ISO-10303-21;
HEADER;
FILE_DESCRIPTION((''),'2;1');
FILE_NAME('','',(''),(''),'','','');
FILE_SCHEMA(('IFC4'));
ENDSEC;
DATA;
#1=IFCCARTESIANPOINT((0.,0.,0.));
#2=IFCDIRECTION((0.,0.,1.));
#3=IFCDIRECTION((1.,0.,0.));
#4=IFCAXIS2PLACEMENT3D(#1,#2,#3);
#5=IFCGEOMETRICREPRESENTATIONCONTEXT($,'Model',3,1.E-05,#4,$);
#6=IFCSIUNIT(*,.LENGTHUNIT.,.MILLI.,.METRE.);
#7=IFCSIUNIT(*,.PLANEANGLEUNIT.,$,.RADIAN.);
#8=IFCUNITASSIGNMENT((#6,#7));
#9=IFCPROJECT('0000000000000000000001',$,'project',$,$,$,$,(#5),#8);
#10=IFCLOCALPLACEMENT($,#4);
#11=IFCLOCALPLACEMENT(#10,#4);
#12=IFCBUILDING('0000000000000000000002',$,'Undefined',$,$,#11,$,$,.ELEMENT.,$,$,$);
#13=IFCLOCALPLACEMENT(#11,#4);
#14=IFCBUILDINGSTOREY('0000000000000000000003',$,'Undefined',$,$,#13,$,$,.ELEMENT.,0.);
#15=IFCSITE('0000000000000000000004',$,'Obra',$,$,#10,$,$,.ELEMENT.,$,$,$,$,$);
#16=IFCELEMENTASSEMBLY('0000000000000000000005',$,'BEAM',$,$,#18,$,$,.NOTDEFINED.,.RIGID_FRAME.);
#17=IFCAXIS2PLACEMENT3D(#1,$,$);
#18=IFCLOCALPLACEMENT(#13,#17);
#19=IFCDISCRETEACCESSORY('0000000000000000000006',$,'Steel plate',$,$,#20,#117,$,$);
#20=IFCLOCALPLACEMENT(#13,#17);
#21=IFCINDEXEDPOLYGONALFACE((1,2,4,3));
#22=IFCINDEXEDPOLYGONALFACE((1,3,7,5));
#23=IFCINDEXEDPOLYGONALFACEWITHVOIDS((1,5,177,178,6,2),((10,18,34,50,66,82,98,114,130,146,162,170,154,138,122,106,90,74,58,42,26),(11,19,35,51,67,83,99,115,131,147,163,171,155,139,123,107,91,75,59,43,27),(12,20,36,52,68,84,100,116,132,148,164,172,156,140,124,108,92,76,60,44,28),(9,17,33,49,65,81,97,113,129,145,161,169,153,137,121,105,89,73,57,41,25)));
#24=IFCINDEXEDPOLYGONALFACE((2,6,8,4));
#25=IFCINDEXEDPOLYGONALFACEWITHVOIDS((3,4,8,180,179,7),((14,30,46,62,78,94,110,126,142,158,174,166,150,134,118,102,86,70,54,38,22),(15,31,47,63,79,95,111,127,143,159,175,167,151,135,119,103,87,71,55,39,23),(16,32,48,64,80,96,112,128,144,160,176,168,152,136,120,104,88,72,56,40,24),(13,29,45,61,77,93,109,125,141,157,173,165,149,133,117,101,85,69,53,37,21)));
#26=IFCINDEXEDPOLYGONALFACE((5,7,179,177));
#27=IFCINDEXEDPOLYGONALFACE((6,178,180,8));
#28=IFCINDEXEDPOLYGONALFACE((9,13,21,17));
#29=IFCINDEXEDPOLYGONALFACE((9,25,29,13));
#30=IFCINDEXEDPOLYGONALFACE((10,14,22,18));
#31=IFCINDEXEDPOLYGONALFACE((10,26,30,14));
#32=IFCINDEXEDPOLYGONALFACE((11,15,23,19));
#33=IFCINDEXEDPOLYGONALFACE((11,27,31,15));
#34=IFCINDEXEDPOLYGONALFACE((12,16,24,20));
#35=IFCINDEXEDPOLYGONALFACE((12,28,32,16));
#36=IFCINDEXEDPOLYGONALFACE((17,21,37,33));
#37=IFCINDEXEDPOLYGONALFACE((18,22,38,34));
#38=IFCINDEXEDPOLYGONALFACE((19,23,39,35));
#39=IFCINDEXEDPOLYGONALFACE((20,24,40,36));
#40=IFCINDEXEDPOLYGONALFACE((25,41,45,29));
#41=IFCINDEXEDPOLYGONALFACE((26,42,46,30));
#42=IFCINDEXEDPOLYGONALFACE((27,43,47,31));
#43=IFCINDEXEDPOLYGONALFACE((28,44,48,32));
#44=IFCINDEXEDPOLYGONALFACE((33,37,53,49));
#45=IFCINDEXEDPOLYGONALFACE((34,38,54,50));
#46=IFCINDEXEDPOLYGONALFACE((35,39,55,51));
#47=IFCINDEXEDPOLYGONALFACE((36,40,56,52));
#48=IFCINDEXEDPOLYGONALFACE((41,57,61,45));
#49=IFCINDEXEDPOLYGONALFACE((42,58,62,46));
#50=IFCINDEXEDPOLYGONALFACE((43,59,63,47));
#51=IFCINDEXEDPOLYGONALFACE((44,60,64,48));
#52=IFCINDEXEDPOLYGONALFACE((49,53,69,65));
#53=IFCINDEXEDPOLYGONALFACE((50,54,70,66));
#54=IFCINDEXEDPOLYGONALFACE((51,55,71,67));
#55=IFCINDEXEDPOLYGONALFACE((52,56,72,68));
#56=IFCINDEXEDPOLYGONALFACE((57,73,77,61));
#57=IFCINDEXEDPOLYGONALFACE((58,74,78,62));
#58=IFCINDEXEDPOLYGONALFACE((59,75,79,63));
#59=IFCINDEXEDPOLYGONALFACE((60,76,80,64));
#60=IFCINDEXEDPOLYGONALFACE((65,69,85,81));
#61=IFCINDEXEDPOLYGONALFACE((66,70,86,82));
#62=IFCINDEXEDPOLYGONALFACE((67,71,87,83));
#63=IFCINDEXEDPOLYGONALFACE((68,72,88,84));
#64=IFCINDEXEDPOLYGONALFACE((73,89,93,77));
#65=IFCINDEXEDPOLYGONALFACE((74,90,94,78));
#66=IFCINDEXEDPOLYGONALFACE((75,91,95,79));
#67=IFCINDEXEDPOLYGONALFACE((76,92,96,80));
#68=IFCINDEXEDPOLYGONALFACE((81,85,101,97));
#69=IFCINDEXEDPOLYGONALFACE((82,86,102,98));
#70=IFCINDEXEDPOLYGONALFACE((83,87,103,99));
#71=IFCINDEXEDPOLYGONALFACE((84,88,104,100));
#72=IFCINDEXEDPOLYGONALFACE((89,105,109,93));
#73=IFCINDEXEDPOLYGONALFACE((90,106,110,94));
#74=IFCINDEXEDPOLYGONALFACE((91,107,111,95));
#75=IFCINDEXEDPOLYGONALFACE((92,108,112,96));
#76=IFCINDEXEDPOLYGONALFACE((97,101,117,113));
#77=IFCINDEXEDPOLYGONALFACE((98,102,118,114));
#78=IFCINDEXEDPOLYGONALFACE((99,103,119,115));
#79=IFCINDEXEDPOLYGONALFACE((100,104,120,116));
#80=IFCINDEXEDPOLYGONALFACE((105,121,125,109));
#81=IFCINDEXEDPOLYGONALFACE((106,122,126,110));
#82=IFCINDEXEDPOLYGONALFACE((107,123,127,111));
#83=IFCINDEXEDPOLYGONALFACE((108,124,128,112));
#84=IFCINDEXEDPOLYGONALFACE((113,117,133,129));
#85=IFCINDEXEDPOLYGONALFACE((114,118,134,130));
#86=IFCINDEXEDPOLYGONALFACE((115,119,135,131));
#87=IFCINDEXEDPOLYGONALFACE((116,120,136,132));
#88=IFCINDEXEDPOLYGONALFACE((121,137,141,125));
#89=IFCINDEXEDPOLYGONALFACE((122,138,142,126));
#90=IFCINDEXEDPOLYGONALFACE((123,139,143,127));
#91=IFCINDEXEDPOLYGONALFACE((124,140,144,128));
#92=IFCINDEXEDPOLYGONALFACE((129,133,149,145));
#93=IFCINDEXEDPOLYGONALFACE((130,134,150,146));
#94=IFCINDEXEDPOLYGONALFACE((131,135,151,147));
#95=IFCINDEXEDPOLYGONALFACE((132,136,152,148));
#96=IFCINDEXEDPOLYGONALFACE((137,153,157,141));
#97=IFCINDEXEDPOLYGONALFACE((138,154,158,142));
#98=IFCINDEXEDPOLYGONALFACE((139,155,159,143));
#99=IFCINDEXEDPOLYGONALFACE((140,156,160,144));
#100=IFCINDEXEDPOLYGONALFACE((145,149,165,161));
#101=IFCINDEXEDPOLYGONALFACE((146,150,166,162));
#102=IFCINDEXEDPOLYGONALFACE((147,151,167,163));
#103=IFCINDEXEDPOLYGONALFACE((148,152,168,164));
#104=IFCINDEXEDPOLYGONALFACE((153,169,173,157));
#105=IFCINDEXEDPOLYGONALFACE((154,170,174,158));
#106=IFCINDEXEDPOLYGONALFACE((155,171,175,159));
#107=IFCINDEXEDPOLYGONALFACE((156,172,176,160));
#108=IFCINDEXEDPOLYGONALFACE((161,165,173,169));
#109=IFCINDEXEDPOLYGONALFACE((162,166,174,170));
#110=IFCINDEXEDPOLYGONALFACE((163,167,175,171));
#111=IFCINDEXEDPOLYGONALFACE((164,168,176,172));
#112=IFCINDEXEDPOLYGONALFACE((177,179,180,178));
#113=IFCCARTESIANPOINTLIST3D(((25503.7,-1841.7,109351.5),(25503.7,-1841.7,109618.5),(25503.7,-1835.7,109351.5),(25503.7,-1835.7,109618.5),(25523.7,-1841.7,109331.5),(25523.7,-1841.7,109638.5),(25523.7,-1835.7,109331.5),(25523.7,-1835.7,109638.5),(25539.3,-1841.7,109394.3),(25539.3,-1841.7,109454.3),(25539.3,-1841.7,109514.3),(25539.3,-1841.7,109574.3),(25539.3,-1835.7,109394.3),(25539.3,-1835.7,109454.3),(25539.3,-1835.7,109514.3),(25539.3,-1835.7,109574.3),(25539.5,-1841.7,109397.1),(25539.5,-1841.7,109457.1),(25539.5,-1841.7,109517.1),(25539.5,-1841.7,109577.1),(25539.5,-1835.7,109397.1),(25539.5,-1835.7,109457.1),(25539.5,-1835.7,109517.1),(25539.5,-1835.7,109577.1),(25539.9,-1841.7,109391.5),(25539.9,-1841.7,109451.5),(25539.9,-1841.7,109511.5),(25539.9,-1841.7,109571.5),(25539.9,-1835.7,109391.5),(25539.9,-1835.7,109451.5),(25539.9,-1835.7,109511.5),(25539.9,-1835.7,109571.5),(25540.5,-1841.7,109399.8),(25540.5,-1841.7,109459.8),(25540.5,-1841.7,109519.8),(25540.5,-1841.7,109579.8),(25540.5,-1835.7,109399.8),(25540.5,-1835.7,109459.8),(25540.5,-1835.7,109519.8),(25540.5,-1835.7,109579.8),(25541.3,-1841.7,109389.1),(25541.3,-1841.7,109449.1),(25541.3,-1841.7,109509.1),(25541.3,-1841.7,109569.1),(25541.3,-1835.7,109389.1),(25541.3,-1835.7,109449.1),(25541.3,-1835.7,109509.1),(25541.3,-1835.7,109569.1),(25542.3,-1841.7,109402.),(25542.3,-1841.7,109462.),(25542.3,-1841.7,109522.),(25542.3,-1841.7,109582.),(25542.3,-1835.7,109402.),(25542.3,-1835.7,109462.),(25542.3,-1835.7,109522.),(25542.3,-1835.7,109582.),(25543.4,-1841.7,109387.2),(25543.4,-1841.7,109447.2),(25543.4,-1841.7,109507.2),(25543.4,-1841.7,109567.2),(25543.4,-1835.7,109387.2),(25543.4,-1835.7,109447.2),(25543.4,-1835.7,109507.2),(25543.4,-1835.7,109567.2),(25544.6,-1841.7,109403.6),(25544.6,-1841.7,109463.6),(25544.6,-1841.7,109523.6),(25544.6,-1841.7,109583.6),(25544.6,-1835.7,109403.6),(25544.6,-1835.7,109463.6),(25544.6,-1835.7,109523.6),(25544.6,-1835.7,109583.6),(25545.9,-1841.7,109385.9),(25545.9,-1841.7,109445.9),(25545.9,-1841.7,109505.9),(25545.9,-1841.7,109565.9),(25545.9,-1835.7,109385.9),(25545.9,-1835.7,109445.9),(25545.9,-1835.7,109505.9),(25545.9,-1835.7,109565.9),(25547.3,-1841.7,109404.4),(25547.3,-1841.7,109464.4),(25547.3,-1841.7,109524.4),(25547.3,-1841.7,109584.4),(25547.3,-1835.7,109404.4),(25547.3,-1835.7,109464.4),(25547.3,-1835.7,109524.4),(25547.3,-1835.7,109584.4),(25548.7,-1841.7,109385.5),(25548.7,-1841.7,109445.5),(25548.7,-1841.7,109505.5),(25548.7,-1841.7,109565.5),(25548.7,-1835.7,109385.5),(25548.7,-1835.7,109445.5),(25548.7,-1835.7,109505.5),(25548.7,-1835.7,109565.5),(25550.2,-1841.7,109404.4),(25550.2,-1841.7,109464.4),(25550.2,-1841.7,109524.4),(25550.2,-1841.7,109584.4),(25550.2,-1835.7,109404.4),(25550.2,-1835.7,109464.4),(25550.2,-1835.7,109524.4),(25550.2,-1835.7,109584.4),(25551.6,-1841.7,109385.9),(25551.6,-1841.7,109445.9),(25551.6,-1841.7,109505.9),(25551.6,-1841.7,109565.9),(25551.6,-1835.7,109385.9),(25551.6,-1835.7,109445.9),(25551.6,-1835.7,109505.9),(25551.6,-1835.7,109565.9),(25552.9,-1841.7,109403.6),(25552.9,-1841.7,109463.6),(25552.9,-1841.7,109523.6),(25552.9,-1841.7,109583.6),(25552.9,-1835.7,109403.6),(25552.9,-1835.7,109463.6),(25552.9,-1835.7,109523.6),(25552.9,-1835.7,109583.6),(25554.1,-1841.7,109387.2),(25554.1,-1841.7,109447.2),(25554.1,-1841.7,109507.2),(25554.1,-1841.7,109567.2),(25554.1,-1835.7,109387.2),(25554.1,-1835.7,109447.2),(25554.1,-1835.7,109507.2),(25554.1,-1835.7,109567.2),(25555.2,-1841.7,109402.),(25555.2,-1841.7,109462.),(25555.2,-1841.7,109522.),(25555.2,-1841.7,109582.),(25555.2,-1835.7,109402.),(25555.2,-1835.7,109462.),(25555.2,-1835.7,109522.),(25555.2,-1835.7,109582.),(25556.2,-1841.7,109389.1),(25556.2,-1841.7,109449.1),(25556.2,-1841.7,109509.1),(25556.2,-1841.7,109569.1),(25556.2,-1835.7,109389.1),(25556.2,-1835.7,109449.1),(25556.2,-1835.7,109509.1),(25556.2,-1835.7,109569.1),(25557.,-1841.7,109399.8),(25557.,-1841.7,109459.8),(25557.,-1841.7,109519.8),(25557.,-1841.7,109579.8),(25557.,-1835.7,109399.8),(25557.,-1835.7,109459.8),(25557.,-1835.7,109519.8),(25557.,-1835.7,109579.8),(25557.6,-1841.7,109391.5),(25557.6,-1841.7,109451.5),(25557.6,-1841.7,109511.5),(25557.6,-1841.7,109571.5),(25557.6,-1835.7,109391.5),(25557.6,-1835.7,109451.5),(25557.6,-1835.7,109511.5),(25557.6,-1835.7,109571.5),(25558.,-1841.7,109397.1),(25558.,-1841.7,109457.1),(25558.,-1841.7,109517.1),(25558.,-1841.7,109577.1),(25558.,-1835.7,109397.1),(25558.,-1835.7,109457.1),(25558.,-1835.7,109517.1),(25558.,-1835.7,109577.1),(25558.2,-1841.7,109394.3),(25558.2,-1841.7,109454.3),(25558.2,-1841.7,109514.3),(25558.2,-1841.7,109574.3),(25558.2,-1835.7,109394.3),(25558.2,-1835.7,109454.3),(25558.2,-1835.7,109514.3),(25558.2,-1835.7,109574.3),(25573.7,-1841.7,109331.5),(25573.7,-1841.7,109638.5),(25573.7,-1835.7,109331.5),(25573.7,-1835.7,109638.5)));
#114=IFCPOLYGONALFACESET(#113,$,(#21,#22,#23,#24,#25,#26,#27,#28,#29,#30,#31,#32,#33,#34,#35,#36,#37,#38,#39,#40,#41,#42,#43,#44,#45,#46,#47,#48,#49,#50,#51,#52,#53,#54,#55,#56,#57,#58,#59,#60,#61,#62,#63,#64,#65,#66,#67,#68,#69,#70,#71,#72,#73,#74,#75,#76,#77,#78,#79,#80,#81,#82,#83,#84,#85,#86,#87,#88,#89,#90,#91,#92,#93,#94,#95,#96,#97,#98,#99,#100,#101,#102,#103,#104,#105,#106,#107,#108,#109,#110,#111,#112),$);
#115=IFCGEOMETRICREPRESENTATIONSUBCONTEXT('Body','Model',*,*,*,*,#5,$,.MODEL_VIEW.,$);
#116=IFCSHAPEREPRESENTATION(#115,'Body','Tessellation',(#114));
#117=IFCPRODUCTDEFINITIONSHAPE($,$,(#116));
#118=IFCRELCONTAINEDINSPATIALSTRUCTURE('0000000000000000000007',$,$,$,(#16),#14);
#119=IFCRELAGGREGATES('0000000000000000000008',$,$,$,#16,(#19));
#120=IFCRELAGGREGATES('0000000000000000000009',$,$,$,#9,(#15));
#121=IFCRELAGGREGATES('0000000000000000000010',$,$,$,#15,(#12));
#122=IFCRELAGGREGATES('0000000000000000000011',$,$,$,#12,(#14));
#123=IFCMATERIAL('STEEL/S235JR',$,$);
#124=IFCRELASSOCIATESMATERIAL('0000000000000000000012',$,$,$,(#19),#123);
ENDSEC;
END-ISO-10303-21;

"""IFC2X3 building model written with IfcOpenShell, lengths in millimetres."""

from ifc_helpers import new_model, si_unit, frame, origin_with_axes, origin_2d_with_axis, place, context, subcontext, project, spatial, polyline, circle, outline, extrude, source, transform, mapped, material, element, aggregate, save


model = new_model("IFC2X3")

# Units and contexts
model_context = context("Model", 3, precision=1e-05, world=origin_with_axes())
body_context = subcontext(model_context, "Body", "Model", "MODEL_VIEW")
ifc_project = project(units=[si_unit("LENGTHUNIT", "METRE", prefix="MILLI"), si_unit("PLANEANGLEUNIT", "RADIAN")], contexts=[model_context])

# Site, building, storey
site_placement = place(None, origin_with_axes())
site = spatial("IfcSite", under=ifc_project, at=site_placement, Name="Obra", CompositionType="ELEMENT")
building_placement = place(site_placement, origin_with_axes())
building = spatial("IfcBuilding", under=site, at=building_placement, Name="Undefined", CompositionType="ELEMENT")
storey_placement = place(building_placement, origin_with_axes())
storey = spatial("IfcBuildingStorey", under=building, at=storey_placement, Name="Undefined", CompositionType="ELEMENT", Elevation=0.0)

# Shared definitions
ifc_material = material(Name="STEEL/S235JR")
shared_shape = source(origin_with_axes(), body_context, "Body", "SweptSolid", [
    extrude(circle(Radius=9.5, at=origin_2d_with_axis()), frame((0.0, -9.8, 0.0), z_axis=(0.0, 1.0, 0.0), x_axis=(1.0, 0.0, 0.0)), (0.0, 0.0, 1.0), 6.2),
])

# Element assembly, discrete accessory, opening
assembly_1_placement = place(storey_placement, origin_with_axes())
assembly_1 = element("IfcElementAssembly", 1, at=assembly_1_placement, inside=storey, Name="BEAM", AssemblyPlace="NOTDEFINED", PredefinedType="RIGID_FRAME")
discrete_accessory_1_placement = place(assembly_1_placement, frame((25573.7, -1838.7, 109331.5), z_axis=(0.0, 1.0, 0.0), x_axis=(-1.0, 0.0, 0.0)))
discrete_accessory_1 = element("IfcDiscreteAccessory", 2, at=discrete_accessory_1_placement, material=ifc_material, Name="Steel plate", context=body_context, shape_type="SweptSolid", body=[
    extrude(outline(polyline([(0.0, 0.0), (50.0, 0.0), (70.0, 20.0), (70.0, 287.0), (50.0, 307.0), (0.0, 307.0), (0.0, 0.0)])), frame((0.0, 0.0, -3.0), z_axis=(0.0, 0.0, 1.0), x_axis=(1.0, 0.0, 0.0)), (0.0, 0.0, 1.0), 6.0),
])
opening_1_placement = place(assembly_1_placement, frame((25513.7, -1832.0, 109650.0), z_axis=(1.0, 0.0, 0.0), x_axis=(0.0, 0.0, -1.0)))
element("IfcOpeningElement", 3, at=opening_1_placement, cuts=discrete_accessory_1, ObjectType="Opening", context=body_context, shape_type="MappedRepresentation", body=[
    mapped(shared_shape, transform((75.0, 0.0, 35.0))),
    mapped(shared_shape, transform((135.0, 0.0, 35.0))),
    mapped(shared_shape, transform((195.0, 0.0, 35.0))),
    mapped(shared_shape, transform((255.0, 0.0, 35.0))),
])
aggregate(assembly_1, [discrete_accessory_1])

save(model, "model.ifc")
